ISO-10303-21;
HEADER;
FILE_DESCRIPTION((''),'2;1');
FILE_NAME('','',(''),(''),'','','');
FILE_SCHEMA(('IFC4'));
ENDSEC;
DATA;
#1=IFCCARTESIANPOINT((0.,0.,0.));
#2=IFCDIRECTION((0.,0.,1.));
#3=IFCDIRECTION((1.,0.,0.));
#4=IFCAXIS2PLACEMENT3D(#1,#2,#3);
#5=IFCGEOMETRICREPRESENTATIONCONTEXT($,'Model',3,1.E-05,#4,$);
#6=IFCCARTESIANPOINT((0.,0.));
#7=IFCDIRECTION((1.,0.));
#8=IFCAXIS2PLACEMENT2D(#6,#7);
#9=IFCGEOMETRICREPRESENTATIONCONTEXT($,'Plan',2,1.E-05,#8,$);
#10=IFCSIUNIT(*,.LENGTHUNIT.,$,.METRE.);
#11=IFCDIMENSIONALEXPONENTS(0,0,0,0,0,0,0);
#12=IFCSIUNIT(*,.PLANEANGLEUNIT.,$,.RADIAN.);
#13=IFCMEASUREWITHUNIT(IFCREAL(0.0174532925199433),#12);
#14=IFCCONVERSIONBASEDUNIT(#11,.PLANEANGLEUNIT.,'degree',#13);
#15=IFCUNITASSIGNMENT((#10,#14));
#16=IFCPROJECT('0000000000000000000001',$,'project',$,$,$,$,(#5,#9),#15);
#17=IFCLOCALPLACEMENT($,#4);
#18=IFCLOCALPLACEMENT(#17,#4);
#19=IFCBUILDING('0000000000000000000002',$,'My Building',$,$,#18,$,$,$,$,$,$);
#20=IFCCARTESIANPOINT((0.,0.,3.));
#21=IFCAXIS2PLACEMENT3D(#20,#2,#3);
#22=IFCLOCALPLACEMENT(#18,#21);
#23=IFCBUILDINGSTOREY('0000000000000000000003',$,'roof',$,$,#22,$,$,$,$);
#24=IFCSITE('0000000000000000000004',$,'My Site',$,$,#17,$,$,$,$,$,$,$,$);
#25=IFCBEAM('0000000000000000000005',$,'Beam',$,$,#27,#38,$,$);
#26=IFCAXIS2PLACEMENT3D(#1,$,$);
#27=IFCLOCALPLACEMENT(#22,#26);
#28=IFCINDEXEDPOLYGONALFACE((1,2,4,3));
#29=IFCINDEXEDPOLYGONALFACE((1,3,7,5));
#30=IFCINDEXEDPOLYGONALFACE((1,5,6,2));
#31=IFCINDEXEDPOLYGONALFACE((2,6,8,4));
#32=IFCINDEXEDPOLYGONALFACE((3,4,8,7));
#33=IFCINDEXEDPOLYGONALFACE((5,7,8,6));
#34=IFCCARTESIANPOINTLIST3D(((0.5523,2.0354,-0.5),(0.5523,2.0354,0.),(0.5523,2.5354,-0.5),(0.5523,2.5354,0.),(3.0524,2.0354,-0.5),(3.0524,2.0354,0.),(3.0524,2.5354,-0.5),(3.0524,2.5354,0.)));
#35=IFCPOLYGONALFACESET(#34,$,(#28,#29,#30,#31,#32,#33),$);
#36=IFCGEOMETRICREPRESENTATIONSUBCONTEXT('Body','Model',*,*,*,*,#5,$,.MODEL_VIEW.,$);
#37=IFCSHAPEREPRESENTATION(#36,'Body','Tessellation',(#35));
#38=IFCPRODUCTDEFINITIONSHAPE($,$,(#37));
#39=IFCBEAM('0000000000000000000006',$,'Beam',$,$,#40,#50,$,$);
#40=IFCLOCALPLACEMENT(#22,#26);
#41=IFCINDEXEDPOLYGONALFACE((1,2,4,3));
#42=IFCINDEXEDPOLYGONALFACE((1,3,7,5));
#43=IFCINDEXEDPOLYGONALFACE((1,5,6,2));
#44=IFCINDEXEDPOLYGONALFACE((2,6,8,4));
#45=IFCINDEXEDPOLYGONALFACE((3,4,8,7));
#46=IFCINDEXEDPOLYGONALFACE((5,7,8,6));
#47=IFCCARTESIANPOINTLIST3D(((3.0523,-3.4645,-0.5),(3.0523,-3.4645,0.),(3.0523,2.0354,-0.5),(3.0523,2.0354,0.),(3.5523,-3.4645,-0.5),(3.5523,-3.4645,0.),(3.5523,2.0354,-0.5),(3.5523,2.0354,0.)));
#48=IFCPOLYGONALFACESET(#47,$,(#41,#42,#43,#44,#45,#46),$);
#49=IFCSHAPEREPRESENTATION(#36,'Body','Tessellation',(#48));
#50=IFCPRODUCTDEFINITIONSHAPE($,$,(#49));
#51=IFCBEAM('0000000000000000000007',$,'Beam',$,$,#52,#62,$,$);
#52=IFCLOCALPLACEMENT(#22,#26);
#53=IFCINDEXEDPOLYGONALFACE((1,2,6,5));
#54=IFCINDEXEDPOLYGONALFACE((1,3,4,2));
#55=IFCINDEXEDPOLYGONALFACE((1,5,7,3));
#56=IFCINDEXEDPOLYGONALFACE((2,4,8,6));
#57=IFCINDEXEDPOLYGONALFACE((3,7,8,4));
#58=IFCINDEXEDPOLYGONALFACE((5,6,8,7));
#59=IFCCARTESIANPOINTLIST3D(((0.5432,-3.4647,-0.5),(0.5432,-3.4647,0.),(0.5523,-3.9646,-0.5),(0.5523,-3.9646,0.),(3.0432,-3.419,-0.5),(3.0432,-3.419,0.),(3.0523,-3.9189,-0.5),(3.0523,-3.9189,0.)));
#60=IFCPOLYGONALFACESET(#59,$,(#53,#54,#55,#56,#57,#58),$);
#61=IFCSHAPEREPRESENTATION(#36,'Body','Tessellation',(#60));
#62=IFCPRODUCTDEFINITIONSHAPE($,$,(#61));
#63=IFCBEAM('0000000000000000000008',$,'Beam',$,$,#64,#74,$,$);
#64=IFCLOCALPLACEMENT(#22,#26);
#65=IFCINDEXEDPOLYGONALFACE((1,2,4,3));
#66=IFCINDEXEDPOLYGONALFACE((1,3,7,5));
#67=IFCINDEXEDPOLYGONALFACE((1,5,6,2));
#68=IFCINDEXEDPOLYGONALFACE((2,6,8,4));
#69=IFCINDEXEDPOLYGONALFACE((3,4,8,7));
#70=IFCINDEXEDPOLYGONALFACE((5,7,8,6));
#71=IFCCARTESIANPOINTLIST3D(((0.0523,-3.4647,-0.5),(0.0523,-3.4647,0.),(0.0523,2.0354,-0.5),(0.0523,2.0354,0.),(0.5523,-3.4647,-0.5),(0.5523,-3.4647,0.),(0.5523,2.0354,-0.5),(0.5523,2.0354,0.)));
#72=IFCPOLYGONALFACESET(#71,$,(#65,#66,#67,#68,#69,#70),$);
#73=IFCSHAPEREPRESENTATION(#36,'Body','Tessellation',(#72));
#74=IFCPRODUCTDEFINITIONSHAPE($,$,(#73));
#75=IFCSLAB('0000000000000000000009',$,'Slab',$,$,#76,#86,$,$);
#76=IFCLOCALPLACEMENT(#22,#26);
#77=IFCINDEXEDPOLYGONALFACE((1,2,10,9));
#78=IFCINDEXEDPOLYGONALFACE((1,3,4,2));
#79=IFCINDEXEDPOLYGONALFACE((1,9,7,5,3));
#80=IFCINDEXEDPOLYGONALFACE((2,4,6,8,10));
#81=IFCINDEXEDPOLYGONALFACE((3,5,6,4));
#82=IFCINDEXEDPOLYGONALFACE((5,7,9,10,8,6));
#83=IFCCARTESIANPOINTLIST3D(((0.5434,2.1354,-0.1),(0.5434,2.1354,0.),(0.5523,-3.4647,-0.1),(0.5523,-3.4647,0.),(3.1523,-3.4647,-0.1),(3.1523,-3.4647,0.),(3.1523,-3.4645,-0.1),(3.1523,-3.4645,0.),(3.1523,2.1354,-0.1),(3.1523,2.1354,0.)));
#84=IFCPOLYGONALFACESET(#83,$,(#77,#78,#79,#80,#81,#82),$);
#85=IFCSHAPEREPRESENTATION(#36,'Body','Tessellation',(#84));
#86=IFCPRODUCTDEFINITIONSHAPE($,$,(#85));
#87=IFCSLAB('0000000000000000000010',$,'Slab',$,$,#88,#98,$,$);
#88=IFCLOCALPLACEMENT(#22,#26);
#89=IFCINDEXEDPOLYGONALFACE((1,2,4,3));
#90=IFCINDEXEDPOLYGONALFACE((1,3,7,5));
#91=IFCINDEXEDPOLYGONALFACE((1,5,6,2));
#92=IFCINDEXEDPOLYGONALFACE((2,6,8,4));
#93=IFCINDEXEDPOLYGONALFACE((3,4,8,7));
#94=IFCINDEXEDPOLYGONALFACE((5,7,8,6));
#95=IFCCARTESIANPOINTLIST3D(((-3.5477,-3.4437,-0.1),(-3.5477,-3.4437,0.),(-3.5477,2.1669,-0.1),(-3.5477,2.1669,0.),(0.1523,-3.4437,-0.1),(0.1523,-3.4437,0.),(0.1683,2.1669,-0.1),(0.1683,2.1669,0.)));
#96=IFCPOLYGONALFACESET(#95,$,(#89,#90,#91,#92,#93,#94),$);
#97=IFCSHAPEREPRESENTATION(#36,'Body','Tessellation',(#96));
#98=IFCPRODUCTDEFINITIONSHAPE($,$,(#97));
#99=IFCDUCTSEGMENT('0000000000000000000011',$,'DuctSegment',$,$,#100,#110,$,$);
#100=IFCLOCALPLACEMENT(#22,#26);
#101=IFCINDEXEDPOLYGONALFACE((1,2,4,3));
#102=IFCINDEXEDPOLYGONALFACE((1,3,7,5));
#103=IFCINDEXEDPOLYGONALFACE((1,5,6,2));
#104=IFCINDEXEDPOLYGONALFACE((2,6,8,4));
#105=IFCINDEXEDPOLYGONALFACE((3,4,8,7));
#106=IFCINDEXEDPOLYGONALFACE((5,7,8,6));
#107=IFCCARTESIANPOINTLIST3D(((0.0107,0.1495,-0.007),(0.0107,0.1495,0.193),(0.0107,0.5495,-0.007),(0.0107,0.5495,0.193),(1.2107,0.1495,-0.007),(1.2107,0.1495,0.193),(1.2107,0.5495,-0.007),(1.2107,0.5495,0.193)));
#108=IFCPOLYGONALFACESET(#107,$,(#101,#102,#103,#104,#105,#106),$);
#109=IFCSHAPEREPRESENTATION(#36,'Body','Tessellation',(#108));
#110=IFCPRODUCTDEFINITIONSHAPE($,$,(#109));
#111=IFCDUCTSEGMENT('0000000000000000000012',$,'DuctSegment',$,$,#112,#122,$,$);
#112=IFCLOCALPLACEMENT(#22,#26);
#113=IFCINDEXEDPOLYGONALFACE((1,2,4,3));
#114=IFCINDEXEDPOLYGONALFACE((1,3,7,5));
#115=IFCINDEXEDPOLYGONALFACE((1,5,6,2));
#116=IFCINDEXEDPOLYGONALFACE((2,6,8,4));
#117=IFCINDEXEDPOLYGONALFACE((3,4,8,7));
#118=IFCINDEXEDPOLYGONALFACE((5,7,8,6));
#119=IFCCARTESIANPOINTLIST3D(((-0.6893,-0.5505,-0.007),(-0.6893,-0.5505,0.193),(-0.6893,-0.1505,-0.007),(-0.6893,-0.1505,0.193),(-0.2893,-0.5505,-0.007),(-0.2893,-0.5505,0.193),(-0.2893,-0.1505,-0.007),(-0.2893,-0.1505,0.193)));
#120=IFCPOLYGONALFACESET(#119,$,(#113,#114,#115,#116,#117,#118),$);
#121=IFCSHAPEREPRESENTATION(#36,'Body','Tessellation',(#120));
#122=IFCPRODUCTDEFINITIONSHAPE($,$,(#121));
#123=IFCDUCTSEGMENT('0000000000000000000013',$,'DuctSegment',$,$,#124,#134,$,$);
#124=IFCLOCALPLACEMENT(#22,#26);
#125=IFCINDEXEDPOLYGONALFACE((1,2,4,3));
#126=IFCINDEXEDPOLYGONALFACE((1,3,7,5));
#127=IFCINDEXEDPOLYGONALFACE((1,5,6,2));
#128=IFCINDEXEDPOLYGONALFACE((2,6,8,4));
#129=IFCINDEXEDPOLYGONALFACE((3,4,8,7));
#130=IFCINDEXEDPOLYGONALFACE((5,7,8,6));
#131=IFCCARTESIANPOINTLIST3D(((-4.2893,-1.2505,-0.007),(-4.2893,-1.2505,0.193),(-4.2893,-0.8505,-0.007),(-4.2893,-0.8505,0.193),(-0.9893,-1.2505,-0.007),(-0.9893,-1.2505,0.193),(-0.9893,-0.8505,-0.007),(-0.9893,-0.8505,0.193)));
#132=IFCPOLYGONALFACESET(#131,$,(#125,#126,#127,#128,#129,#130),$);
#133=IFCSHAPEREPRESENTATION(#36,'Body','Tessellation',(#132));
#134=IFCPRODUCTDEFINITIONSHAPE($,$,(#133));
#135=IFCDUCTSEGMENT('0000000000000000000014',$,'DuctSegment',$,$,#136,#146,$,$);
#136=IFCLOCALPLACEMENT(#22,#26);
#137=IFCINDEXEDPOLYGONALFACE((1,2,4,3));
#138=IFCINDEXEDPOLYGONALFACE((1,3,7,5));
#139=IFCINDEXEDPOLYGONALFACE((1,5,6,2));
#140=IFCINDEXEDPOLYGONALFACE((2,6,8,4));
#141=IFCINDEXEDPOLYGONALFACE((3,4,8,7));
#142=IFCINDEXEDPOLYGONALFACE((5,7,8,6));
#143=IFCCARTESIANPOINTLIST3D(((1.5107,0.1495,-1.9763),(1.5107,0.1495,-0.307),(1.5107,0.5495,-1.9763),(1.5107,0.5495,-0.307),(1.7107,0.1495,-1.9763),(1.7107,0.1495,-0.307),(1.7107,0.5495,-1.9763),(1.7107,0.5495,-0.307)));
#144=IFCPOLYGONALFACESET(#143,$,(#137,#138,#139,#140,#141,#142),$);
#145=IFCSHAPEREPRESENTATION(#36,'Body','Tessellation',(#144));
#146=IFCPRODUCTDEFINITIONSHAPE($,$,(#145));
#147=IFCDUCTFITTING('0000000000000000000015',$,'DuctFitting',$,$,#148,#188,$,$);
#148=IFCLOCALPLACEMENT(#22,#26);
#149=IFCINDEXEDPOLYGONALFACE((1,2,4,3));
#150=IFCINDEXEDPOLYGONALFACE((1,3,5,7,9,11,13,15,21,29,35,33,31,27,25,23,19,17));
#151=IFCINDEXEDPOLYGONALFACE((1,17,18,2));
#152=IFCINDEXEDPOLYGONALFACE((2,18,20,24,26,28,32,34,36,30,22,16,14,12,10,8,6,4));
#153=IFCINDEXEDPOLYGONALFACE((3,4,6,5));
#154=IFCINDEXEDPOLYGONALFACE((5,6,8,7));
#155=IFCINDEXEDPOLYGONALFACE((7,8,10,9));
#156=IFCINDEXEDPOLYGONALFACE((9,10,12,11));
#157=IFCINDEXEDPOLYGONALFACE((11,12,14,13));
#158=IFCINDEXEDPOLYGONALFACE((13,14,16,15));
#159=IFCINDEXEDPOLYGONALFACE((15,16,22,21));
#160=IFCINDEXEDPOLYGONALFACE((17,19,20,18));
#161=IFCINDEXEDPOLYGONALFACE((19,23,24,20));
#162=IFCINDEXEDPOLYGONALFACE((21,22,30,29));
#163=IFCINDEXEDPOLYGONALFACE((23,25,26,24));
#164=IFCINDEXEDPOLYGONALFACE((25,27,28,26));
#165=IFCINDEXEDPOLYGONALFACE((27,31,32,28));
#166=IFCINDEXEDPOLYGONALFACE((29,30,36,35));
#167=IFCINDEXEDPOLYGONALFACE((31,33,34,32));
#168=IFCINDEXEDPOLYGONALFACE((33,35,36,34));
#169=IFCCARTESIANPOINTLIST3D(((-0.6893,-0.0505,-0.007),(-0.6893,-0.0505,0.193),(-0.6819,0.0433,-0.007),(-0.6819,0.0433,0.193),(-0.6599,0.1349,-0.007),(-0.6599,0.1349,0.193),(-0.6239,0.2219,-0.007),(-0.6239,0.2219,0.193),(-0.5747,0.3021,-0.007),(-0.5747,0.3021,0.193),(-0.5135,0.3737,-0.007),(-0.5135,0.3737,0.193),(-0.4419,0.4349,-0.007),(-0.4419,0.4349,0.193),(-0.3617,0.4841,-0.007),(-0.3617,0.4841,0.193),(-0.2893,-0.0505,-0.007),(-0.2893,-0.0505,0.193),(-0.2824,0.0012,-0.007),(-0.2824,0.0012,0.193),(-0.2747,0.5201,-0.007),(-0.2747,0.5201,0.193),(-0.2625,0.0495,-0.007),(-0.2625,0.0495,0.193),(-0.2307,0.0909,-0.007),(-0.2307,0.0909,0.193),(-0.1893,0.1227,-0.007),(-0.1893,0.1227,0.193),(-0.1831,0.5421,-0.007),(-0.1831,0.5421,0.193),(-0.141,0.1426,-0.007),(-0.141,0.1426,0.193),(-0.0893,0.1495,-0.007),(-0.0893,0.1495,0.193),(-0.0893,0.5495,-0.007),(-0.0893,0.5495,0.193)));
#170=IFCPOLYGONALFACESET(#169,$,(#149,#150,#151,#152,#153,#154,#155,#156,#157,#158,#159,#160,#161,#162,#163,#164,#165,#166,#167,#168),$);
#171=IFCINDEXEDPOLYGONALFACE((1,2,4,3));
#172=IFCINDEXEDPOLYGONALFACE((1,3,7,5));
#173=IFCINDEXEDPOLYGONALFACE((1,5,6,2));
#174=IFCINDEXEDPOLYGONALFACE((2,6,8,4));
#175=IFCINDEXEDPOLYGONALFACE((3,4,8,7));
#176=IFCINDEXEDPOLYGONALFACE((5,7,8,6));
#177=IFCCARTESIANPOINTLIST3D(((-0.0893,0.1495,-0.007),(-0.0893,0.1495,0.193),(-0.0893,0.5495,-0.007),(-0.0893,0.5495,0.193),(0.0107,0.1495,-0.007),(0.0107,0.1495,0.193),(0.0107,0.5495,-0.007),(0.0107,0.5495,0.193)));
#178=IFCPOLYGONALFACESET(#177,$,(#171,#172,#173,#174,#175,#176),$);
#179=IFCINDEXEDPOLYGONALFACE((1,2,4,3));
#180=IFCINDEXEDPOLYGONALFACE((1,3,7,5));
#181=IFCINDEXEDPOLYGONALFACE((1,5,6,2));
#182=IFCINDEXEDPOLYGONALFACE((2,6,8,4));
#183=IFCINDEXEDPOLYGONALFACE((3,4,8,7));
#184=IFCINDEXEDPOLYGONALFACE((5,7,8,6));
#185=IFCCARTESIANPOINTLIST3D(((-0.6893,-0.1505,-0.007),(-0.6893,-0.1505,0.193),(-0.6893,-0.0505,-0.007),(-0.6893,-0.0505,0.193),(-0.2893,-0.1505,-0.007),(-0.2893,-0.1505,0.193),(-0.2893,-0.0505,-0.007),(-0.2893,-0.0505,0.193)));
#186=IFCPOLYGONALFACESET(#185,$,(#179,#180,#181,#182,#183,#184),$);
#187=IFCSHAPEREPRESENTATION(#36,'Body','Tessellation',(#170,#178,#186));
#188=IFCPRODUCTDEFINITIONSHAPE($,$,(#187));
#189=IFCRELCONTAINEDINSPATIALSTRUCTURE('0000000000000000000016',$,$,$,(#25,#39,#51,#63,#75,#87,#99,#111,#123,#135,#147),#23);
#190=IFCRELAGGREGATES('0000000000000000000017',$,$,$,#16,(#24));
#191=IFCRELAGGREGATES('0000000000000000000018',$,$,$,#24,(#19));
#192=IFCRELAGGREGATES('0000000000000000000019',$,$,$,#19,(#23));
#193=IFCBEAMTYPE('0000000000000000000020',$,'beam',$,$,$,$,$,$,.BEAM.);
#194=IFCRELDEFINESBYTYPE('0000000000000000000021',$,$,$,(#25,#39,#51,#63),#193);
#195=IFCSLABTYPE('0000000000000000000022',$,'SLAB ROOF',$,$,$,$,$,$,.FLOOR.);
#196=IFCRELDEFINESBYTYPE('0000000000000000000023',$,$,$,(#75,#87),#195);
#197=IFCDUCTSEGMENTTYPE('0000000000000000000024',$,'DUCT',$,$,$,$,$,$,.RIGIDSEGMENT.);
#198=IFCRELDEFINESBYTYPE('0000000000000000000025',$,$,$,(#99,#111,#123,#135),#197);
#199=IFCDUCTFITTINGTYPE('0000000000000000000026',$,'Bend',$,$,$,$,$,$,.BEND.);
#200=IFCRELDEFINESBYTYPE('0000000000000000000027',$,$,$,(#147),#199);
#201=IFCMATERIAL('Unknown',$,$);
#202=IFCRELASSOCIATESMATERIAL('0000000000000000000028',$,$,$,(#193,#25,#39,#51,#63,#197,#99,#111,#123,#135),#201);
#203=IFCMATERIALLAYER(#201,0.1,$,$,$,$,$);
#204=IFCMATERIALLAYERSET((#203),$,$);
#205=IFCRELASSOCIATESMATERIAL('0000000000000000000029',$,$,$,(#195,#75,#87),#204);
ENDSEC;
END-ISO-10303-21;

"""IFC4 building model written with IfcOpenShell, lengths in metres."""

from ifc_helpers import new_model, entity, si_unit, converted_unit, frame, origin_with_axes, origin_2d_with_axis, place, context, subcontext, project, spatial, line, arc, indexed_curve, rectangle, outline, extrude, source, transform, mapped, material, layer, layer_set, layer_usage, material_profile, profile_set, profile_usage, type_object, type_shapes, element, save


model = new_model("IFC4")

# Units and contexts
model_context = context("Model", 3, precision=1e-05, world=origin_with_axes())
plan_context = context("Plan", 2, precision=1e-05, world=origin_2d_with_axis())
body_context = subcontext(model_context, "Body", "Model", "MODEL_VIEW")
ifc_project = project(units=[si_unit("LENGTHUNIT", "METRE"), converted_unit("PLANEANGLEUNIT", "degree", entity("IfcReal", 0.0174532925199433), si_unit("PLANEANGLEUNIT", "RADIAN"), dimensions=[0, 0, 0, 0, 0, 0, 0])], contexts=[model_context, plan_context])

# Site, building, storey
site_placement = place(None, origin_with_axes())
site = spatial("IfcSite", under=ifc_project, at=site_placement, Name="My Site")
building_placement = place(site_placement, origin_with_axes())
building = spatial("IfcBuilding", under=site, at=building_placement, Name="My Building")
storey_placement = place(building_placement, frame((0.0, 0.0, 3.0), z_axis=(0.0, 0.0, 1.0), x_axis=(1.0, 0.0, 0.0)))
storey = spatial("IfcBuildingStorey", under=building, at=storey_placement, Name="roof")

# Beams
ifc_material = material(Name="Unknown")
ifc_material_profile_1 = material_profile(ifc_material, rectangle(XDim=0.5, YDim=0.5))
ifc_profile_set_1 = profile_set([ifc_material_profile_1])
ifc_profile_usage_1 = profile_usage(ifc_profile_set_1, cardinal=7)
beam_type = type_object("IfcBeamType", Name="beam", PredefinedType="BEAM", material=ifc_profile_set_1)
beam_1_placement = place(storey_placement, frame((0.5523, 2.5354, 0.0), z_axis=(1.0, 0.0, 0.0), x_axis=(0.0, 1.0, 0.0)))
element("IfcBeam", 1, at=beam_1_placement, inside=storey, type_object=beam_type, material=ifc_profile_usage_1, Name="Beam", context=body_context, shape_type="SweptSolid", body=[
    extrude(rectangle(XDim=0.5, YDim=0.5), frame((-0.25, -0.25, 0.0), z_axis=(0.0, 0.0, 1.0), x_axis=(1.0, 0.0, 0.0)), (0.0, 0.0, 1.0), 2.5001),
])
ifc_profile_usage_2 = profile_usage(ifc_profile_set_1, cardinal=7)
beam_2_placement = place(storey_placement, frame((3.5523, 2.0354, 0.0), z_axis=(0.0, -1.0, 0.0), x_axis=(1.0, 0.0, 0.0)))
element("IfcBeam", 2, at=beam_2_placement, inside=storey, type_object=beam_type, material=ifc_profile_usage_2, Name="Beam", context=body_context, shape_type="SweptSolid", body=[
    extrude(rectangle(XDim=0.5, YDim=0.5), frame((-0.25, -0.25, 0.0), z_axis=(0.0, 0.0, 1.0), x_axis=(1.0, 0.0, 0.0)), (0.0, 0.0, 1.0), 5.4999),
])
ifc_profile_usage_3 = profile_usage(ifc_profile_set_1, cardinal=7)
beam_3_placement = place(storey_placement, frame((3.0523, -3.9189, 0.0), z_axis=(-0.999833, -0.018265, 0.0), x_axis=(0.018265, -0.999833, 0.0)))
element("IfcBeam", 3, at=beam_3_placement, inside=storey, type_object=beam_type, material=ifc_profile_usage_3, Name="Beam", context=body_context, shape_type="SweptSolid", body=[
    extrude(rectangle(XDim=0.5, YDim=0.5), frame((-0.25, -0.25, 0.0), z_axis=(0.0, 0.0, 1.0), x_axis=(1.0, 0.0, 0.0)), (0.0, 0.0, 1.0), 2.5004),
])
ifc_profile_usage_4 = profile_usage(ifc_profile_set_1, cardinal=7)
beam_4_placement = place(storey_placement, frame((0.5523, 2.0354, 0.0), z_axis=(0.0, -1.0, 0.0), x_axis=(1.0, 0.0, 0.0)))
element("IfcBeam", 4, at=beam_4_placement, inside=storey, type_object=beam_type, material=ifc_profile_usage_4, Name="Beam", context=body_context, shape_type="SweptSolid", body=[
    extrude(rectangle(XDim=0.5, YDim=0.5), frame((-0.25, -0.25, 0.0), z_axis=(0.0, 0.0, 1.0), x_axis=(1.0, 0.0, 0.0)), (0.0, 0.0, 1.0), 5.5001),
])

# Slabs
ifc_layer = layer(ifc_material, 0.1)
ifc_layer_set = layer_set([ifc_layer])
ifc_layer_usage_1 = layer_usage(ifc_layer_set, "AXIS3", "POSITIVE", -0.1)
slab_type = type_object("IfcSlabType", Name="SLAB ROOF", PredefinedType="FLOOR", material=ifc_layer_set)
slab_1_placement = place(storey_placement, frame((0.5434, 2.1354, 0.0), z_axis=(0.0, 0.0, 1.0), x_axis=(1.0, 0.0, 0.0)))
element("IfcSlab", 5, at=slab_1_placement, inside=storey, type_object=slab_type, material=ifc_layer_usage_1, Name="Slab", context=body_context, shape_type="SweptSolid", body=[
    extrude(outline(indexed_curve([(0.0, 0.0), (2.6089, 0.0), (2.6089, -5.5999), (2.6089, -5.6001), (0.0089, -5.6001), (0.0, 0.0)])), frame((0.0, 0.0, -0.1), z_axis=(0.0, 0.0, 1.0), x_axis=(1.0, 0.0, 0.0)), (0.0, 0.0, 1.0), 0.1),
])
ifc_layer_usage_2 = layer_usage(ifc_layer_set, "AXIS3", "POSITIVE", -0.1)
slab_2_placement = place(storey_placement, frame((0.1523, -3.4437, 0.0), z_axis=(0.0, 0.0, 1.0), x_axis=(1.0, 0.0, 0.0)))
element("IfcSlab", 6, at=slab_2_placement, inside=storey, type_object=slab_type, material=ifc_layer_usage_2, Name="Slab", context=body_context, shape_type="SweptSolid", body=[
    extrude(outline(indexed_curve([(0.0, 0.0), (-3.7, 0.0), (-3.7, 5.6106), (0.016, 5.6106), (0.0, 0.0)])), frame((0.0, 0.0, -0.1), z_axis=(0.0, 0.0, 1.0), x_axis=(1.0, 0.0, 0.0)), (0.0, 0.0, 1.0), 0.1),
])

# Duct segments
ifc_material_profile_2 = material_profile(ifc_material, rectangle(XDim=0.4, YDim=0.2))
ifc_profile_set_2 = profile_set([ifc_material_profile_2])
ifc_profile_usage_5 = profile_usage(ifc_profile_set_2, cardinal=5)
duct_segment_type = type_object("IfcDuctSegmentType", Name="DUCT", PredefinedType="RIGIDSEGMENT", material=ifc_profile_set_2)
duct_segment_1_placement = place(storey_placement, frame((1.2107, 0.3495, 0.093), z_axis=(-1.0, 0.0, 0.0), x_axis=(0.0, -1.0, 0.0)))
element("IfcDuctSegment", 7, at=duct_segment_1_placement, inside=storey, type_object=duct_segment_type, material=ifc_profile_usage_5, Name="DuctSegment", context=body_context, shape_type="SweptSolid", body=[
    extrude(rectangle(XDim=0.4, YDim=0.2), origin_with_axes(), (0.0, 0.0, 1.0), 1.2),
])
ifc_profile_usage_6 = profile_usage(ifc_profile_set_2, cardinal=5)
duct_segment_2_placement = place(storey_placement, frame((-0.4893, -0.1505, 0.093), z_axis=(0.0, -1.0, -0.000002), x_axis=(1.0, 0.0, 0.0)))
element("IfcDuctSegment", 8, at=duct_segment_2_placement, inside=storey, type_object=duct_segment_type, material=ifc_profile_usage_6, Name="DuctSegment", context=body_context, shape_type="SweptSolid", body=[
    extrude(rectangle(XDim=0.4, YDim=0.2), origin_with_axes(), (0.0, 0.0, 1.0), 0.4),
])
ifc_profile_usage_7 = profile_usage(ifc_profile_set_2, cardinal=5)
duct_segment_3_placement = place(storey_placement, frame((-0.9893, -1.0505, 0.093), z_axis=(-1.0, 0.0, 0.0), x_axis=(0.0, -1.0, 0.0)))
element("IfcDuctSegment", 9, at=duct_segment_3_placement, inside=storey, type_object=duct_segment_type, material=ifc_profile_usage_7, Name="DuctSegment", context=body_context, shape_type="SweptSolid", body=[
    extrude(rectangle(XDim=0.4, YDim=0.2), origin_with_axes(), (0.0, 0.0, 1.0), 3.3),
])
ifc_profile_usage_8 = profile_usage(ifc_profile_set_2, cardinal=5)
duct_segment_4_placement = place(storey_placement, frame((1.6107, 0.3495, -0.307), z_axis=(0.0, 0.0, -1.0), x_axis=(0.0, -1.0, 0.0)))
element("IfcDuctSegment", 10, at=duct_segment_4_placement, inside=storey, type_object=duct_segment_type, material=ifc_profile_usage_8, Name="DuctSegment", context=body_context, shape_type="SweptSolid", body=[
    extrude(rectangle(XDim=0.4, YDim=0.2), origin_with_axes(), (0.0, 0.0, 1.0), 1.6693),
])

# Duct fitting
duct_fitting_type_1 = type_object("IfcDuctFittingType", Name="Bend", PredefinedType="BEND")
shared_shape_1 = source(origin_with_axes(), body_context, "Body", "SweptSolid", [
    extrude(outline(indexed_curve([(-0.2, 0.0), (-0.2586, 0.1414), (-0.4, 0.2), (-0.4, 0.6), (0.0243, 0.4243), (0.2, 0.0)], segments=[arc(1, 2, 3), line(3, 4), arc(4, 5, 6), line(6, 1)])), frame((0.0, -0.1, 0.1), z_axis=(0.0, -1.0, 0.0), x_axis=(1.0, 0.0, 0.0)), (0.0, 0.0, -1.0), 0.2),
    extrude(rectangle(XDim=0.4, YDim=0.2), origin_with_axes(), (0.0, 0.0, 1.0), 0.1),
    extrude(rectangle(XDim=0.4, YDim=0.2), frame((-0.4, 0.0, 0.5), z_axis=(-1.0, 0.0, 0.0), x_axis=(0.0, 0.0, -1.0)), (0.0, 0.0, 1.0), 0.1),
])
type_shapes(duct_fitting_type_1, [shared_shape_1])
for number, where, z_axis, x_axis, name in (
    (11, (0.0107, 0.3495, 0.093), (-1.0, 0.0, 0.0), (0.0, 1.0, 0.0), "DuctFitting"),
):
    element("IfcDuctFitting", number, at=place(storey_placement, frame(where, z_axis=z_axis, x_axis=x_axis)), inside=storey, type_object=duct_fitting_type_1, Name=name, context=body_context, shape_type="MappedRepresentation", body=[
        mapped(shared_shape_1, transform((0.0, 0.0, 0.0), x_axis=(1.0, 0.0, 0.0), y_axis=(0.0, 1.0, 0.0), z_axis=(0.0, 0.0, 1.0), scale=1.0)),
    ])

save(model, "model.ifc")
